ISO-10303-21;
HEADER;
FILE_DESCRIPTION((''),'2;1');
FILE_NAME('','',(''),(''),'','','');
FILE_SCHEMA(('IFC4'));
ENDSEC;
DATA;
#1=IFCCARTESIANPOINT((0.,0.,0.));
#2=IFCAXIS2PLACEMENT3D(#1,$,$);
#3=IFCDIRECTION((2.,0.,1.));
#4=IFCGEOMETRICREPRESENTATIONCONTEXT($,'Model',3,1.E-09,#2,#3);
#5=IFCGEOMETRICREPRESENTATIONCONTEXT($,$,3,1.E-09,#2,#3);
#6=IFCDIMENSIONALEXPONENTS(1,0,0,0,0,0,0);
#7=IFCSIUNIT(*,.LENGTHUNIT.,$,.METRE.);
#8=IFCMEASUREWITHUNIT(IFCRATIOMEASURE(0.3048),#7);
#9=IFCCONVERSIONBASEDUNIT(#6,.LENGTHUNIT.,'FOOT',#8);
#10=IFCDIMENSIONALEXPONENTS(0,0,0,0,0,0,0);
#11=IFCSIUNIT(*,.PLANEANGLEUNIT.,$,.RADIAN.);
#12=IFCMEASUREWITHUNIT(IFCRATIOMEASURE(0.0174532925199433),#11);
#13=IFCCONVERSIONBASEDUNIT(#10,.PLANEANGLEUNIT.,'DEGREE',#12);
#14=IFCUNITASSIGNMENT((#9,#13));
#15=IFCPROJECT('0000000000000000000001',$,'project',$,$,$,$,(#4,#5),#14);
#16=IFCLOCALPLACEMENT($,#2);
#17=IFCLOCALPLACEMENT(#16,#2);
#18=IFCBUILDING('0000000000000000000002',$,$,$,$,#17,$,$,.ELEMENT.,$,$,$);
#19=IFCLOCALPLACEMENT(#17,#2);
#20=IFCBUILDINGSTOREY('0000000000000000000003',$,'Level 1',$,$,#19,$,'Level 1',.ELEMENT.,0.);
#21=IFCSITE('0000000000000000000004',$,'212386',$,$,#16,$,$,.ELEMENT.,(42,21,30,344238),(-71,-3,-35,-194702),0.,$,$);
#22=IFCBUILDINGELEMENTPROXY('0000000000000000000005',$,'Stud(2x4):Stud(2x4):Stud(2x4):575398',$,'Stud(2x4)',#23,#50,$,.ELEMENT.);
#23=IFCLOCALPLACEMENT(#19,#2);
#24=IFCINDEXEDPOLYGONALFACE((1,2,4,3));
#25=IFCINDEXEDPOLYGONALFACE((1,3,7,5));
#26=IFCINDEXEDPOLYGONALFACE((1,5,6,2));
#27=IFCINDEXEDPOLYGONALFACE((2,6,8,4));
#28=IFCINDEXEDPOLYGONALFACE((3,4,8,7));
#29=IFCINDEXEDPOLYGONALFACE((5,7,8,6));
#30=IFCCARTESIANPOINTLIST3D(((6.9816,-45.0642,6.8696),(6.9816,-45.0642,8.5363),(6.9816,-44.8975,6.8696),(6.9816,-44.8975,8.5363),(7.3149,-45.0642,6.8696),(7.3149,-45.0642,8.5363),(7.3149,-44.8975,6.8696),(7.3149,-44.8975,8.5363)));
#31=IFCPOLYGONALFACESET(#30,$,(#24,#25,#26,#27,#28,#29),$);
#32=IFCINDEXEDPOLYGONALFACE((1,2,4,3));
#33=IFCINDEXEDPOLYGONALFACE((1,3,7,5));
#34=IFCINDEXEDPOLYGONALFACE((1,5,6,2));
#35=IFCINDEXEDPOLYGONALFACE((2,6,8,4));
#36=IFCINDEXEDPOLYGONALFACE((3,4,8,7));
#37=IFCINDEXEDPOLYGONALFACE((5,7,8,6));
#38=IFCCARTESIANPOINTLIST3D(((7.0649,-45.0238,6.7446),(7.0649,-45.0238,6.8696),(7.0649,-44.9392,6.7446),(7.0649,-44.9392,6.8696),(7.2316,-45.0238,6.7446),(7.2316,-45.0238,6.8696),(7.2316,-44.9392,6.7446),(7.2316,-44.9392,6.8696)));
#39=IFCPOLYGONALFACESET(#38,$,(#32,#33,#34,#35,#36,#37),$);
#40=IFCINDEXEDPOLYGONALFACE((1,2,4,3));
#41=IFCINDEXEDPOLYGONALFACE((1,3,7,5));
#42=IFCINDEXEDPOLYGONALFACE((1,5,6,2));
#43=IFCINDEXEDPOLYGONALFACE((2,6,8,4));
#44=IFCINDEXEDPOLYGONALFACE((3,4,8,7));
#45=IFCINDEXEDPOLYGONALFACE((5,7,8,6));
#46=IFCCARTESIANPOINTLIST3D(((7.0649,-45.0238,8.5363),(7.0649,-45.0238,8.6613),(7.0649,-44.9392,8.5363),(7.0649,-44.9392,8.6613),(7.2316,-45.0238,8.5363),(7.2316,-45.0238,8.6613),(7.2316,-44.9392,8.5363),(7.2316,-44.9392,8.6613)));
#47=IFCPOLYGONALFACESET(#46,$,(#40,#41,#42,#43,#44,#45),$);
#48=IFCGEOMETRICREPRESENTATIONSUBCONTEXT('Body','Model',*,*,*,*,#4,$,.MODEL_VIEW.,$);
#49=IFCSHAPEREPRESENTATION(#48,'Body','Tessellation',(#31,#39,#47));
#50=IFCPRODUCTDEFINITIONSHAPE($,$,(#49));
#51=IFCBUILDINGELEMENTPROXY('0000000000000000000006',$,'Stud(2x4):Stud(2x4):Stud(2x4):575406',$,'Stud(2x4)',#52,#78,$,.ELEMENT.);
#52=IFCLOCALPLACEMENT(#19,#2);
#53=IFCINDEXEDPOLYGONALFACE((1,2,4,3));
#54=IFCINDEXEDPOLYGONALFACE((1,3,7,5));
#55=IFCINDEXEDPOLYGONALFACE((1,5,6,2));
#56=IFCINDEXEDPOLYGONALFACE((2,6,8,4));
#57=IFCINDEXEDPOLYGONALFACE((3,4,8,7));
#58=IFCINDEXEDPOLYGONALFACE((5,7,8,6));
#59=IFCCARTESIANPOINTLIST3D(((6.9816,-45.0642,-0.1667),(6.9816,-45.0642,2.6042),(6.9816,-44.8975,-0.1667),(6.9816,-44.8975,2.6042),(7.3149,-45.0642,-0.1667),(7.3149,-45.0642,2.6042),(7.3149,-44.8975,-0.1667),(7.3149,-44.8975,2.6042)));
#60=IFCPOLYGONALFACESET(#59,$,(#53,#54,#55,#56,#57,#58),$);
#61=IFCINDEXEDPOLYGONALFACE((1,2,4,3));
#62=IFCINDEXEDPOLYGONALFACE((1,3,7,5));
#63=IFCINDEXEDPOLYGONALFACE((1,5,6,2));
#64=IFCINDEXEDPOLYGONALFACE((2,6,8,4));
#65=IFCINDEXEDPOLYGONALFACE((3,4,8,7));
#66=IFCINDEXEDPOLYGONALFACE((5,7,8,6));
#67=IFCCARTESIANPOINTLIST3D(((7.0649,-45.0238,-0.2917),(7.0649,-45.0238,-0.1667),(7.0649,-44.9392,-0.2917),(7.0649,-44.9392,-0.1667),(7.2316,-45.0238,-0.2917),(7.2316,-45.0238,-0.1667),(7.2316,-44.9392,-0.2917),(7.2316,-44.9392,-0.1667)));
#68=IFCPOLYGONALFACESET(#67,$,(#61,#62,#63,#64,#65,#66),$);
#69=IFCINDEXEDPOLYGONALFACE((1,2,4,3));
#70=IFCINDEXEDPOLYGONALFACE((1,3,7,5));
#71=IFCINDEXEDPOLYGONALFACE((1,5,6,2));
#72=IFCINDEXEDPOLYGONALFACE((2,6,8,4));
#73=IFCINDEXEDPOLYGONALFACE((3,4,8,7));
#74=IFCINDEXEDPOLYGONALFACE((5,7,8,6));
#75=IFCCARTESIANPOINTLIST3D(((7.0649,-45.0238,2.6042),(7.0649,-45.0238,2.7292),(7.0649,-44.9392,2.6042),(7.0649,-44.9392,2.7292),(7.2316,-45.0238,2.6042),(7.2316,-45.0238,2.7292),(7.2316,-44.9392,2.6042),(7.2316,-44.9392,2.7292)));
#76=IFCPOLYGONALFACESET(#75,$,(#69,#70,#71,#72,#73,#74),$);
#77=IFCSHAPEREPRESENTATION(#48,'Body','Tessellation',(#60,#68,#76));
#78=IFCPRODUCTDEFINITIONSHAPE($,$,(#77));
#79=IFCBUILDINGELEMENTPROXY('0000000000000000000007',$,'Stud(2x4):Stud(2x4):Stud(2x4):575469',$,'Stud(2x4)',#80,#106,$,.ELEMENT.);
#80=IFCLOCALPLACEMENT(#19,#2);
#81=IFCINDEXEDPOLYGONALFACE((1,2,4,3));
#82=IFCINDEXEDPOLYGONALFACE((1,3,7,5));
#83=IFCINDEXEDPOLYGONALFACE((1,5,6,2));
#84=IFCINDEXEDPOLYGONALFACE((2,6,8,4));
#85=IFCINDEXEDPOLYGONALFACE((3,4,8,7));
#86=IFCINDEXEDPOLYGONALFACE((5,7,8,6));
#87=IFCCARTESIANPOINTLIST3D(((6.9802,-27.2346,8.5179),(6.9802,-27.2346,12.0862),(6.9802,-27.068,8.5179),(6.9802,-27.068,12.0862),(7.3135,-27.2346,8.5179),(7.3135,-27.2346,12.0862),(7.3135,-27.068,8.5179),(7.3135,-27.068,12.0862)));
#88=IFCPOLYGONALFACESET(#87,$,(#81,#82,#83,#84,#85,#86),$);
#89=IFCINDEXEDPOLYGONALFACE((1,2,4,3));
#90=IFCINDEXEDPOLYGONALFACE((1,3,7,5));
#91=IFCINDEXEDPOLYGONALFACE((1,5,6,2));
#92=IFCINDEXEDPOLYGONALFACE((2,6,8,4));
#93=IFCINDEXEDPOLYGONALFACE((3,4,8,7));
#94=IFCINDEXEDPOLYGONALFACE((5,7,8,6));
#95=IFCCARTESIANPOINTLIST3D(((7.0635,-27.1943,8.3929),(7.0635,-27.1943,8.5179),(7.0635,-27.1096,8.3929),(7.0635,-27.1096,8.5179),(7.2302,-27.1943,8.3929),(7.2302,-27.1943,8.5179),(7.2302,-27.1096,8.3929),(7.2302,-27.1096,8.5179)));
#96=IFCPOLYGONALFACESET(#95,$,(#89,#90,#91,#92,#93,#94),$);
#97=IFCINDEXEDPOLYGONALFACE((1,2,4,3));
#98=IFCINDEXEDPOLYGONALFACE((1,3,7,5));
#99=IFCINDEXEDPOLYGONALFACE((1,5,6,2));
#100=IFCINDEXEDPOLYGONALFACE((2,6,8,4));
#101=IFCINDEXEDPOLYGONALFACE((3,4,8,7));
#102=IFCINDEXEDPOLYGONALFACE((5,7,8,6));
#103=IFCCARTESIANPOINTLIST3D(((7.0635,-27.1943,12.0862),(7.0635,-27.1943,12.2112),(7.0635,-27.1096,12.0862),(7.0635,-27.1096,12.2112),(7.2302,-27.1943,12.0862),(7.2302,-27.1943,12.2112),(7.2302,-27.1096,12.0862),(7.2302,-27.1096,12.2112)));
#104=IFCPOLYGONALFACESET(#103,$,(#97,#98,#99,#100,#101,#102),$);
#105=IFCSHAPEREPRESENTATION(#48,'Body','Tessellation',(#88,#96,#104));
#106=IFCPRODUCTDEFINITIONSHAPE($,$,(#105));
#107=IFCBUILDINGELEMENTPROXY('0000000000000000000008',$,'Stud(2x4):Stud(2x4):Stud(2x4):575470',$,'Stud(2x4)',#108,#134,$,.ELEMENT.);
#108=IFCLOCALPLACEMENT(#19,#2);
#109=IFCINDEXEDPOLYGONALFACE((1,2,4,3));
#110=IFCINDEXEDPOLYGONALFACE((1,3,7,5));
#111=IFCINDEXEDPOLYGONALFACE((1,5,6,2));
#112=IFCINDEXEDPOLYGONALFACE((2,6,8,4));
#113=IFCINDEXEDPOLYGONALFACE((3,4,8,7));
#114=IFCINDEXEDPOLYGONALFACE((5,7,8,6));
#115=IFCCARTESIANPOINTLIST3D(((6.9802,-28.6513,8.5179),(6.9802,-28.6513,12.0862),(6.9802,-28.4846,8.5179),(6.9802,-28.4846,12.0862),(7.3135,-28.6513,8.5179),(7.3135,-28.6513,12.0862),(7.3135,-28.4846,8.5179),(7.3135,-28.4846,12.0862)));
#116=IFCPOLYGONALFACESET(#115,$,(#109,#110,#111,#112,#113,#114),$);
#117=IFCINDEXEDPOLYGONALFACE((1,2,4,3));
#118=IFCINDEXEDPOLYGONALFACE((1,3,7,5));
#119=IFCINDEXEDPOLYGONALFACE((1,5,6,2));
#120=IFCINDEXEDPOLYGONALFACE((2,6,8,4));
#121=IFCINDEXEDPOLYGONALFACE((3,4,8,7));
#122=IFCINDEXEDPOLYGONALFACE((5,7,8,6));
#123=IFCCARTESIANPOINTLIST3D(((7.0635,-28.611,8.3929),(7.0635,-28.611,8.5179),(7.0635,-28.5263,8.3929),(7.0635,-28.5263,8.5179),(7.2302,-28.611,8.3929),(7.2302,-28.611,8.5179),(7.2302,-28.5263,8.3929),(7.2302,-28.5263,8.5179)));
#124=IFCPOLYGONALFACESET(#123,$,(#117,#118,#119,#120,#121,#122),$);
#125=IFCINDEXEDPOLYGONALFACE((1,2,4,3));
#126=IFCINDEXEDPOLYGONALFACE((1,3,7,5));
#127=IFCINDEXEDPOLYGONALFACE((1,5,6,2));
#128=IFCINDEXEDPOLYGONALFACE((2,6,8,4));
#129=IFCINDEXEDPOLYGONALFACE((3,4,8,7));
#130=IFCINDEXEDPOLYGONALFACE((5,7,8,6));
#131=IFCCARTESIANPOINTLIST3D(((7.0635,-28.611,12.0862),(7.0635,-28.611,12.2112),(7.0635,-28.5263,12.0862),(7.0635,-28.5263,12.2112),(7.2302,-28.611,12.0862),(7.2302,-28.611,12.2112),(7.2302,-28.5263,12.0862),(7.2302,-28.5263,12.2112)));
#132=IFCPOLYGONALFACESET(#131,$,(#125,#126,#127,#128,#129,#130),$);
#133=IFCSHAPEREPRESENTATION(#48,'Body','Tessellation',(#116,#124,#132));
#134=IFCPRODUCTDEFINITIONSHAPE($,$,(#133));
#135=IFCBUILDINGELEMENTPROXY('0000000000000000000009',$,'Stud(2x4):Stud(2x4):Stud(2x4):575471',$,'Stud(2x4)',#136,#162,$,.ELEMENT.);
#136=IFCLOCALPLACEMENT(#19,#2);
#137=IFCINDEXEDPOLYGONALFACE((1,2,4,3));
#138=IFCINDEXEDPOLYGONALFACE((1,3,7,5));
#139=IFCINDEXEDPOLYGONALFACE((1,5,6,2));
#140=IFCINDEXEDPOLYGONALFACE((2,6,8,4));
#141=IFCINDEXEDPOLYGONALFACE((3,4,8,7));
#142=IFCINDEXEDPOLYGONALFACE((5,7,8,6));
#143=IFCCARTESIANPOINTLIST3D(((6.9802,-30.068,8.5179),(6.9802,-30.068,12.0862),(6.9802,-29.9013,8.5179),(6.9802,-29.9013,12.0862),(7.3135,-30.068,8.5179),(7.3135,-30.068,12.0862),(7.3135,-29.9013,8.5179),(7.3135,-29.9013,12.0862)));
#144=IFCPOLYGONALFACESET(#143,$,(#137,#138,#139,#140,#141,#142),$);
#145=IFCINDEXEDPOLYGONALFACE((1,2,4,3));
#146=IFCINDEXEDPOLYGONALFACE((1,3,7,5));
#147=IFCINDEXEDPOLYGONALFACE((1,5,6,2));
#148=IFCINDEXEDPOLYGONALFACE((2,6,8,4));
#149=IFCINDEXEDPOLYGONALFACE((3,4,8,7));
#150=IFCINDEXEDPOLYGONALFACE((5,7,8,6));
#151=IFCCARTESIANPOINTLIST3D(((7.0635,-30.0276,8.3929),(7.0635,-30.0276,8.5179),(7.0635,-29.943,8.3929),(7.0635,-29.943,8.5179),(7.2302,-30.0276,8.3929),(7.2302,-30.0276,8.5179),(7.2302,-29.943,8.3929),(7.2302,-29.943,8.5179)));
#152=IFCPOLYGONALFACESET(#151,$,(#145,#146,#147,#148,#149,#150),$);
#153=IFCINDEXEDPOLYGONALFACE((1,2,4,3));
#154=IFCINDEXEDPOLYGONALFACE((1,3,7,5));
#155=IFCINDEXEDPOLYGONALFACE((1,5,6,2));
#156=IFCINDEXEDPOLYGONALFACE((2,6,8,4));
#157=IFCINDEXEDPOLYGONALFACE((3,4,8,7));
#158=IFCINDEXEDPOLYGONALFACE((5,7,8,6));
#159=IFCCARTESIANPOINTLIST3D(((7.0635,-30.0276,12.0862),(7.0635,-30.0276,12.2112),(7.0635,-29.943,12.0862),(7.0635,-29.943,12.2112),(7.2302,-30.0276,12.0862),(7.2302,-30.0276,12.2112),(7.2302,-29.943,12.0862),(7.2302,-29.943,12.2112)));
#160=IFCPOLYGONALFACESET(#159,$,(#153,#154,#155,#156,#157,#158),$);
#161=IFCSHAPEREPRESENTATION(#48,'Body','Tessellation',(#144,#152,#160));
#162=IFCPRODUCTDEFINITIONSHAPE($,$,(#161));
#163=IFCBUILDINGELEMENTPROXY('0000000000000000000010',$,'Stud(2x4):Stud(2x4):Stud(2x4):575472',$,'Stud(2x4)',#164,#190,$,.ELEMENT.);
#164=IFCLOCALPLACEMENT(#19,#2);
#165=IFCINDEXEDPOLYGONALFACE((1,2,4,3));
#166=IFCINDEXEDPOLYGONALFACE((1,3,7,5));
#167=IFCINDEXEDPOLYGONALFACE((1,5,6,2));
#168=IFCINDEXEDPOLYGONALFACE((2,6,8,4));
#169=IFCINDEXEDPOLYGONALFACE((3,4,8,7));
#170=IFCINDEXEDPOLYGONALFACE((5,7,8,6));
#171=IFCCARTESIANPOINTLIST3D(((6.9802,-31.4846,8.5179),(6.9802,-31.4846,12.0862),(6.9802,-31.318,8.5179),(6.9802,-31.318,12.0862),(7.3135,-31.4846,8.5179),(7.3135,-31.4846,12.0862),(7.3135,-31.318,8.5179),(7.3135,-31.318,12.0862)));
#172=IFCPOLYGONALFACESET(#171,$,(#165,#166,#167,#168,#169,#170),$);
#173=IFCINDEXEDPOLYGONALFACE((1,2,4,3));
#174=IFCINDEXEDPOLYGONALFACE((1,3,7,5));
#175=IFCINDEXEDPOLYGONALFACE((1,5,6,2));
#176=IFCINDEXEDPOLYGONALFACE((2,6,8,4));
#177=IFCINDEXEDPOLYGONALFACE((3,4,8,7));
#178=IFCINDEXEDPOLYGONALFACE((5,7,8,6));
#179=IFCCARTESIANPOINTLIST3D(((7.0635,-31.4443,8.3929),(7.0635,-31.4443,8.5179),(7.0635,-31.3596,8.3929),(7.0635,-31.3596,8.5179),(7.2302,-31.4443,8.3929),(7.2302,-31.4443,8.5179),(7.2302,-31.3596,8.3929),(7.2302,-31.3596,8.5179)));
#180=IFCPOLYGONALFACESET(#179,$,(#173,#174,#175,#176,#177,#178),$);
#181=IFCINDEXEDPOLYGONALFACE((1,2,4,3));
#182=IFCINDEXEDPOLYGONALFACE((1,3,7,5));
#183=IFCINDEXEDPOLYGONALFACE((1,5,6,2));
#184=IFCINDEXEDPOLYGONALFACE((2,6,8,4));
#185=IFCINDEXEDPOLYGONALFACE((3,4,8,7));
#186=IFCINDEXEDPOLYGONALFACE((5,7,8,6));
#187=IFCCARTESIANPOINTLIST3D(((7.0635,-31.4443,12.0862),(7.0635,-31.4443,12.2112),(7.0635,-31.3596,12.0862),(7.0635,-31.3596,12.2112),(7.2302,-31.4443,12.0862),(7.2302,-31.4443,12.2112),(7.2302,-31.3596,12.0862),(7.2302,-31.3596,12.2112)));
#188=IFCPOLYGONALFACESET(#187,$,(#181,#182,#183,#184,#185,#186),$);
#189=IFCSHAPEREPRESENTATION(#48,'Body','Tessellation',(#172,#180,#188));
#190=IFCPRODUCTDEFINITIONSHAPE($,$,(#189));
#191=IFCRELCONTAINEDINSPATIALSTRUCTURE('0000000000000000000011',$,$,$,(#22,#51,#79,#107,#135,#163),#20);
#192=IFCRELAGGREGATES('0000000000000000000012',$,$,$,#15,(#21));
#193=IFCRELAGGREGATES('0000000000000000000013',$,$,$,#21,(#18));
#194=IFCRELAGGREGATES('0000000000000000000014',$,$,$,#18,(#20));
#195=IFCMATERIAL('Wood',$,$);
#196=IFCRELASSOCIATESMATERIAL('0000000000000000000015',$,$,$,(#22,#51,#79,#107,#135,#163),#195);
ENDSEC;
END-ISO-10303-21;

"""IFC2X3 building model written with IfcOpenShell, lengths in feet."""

from ifc_helpers import new_model, entity, si_unit, converted_unit, direction, frame, frame_2d, origin, place, context, subcontext, project, spatial, rectangle, extrude, source, transform, mapped, material, element, save


model = new_model("IFC2X3")

# Units and contexts
model_context = context("Model", 3, precision=1e-09, world=origin(), true_north=direction((2.0, 0.0, 1.0)))
context_of_model = context(None, 3, precision=1e-09, world=origin(), true_north=direction((2.0, 0.0, 1.0)))
body_context = subcontext(model_context, "Body", "Model", "MODEL_VIEW")
ifc_project = project(units=[converted_unit("LENGTHUNIT", "FOOT", entity("IfcRatioMeasure", 0.3048), si_unit("LENGTHUNIT", "METRE"), dimensions=[1, 0, 0, 0, 0, 0, 0]), converted_unit("PLANEANGLEUNIT", "DEGREE", entity("IfcRatioMeasure", 0.0174532925199433), si_unit("PLANEANGLEUNIT", "RADIAN"), dimensions=[0, 0, 0, 0, 0, 0, 0])], contexts=[model_context, context_of_model])

# Site, building, storey
site_placement = place(None, origin())
site = spatial("IfcSite", under=ifc_project, at=site_placement, Name="212386", CompositionType="ELEMENT", RefLatitude=(42, 21, 30, 344238), RefLongitude=(-71, -3, -35, -194702), RefElevation=0.0)
building_placement = place(site_placement, origin())
building = spatial("IfcBuilding", under=site, at=building_placement, CompositionType="ELEMENT")
storey_placement = place(building_placement, origin())
storey = spatial("IfcBuildingStorey", under=building, at=storey_placement, Name="Level 1", LongName="Level 1", CompositionType="ELEMENT", Elevation=0.0)

# Building element proxies
ifc_material = material(Name="Wood")
shared_shape_1 = source(origin(), body_context, "Body", "SweptSolid", [
    extrude(rectangle(XDim=0.3333, YDim=0.1667, at=frame_2d((0.0, 0.0), x_axis=(1.0, 0.0))), frame((7.1482, -44.9808, 6.8696), z_axis=(0.0, 0.0, 1.0), x_axis=(-1.0, 0.0, 0.0)), (0.0, 0.0, 1.0), 1.6667),
    extrude(rectangle(XDim=0.1667, YDim=0.0847, at=frame_2d((0.0, 0.0), x_axis=(1.0, 0.0))), frame((7.1482, -44.9815, 6.7446), z_axis=(0.0, 0.0, 1.0), x_axis=(-1.0, 0.0, 0.0)), (0.0, 0.0, 1.0), 0.125),
    extrude(rectangle(XDim=0.0847, YDim=0.1667, at=frame_2d((0.0, 0.0), x_axis=(1.0, 0.0))), frame((7.1482, -44.9815, 8.5363), z_axis=(0.0, 0.0, 1.0), x_axis=(0.0, -1.0, 0.0)), (0.0, 0.0, 1.0), 0.125),
])
proxy_1_placement = place(storey_placement, origin())
element("IfcBuildingElementProxy", 1, at=proxy_1_placement, inside=storey, material=ifc_material, Name="Stud(2x4):Stud(2x4):Stud(2x4):575398", ObjectType="Stud(2x4)", CompositionType="ELEMENT", context=body_context, shape_type="MappedRepresentation", body=[
    mapped(shared_shape_1, transform((0.0, 0.0, 0.0), scale=1.0)),
])
shared_shape_2 = source(origin(), body_context, "Body", "SweptSolid", [
    extrude(rectangle(XDim=0.3333, YDim=0.1667, at=frame_2d((0.0, 0.0), x_axis=(1.0, 0.0))), frame((7.1482, -44.9808, -0.1667), z_axis=(0.0, 0.0, 1.0), x_axis=(-1.0, 0.0, 0.0)), (0.0, 0.0, 1.0), 2.7708),
    extrude(rectangle(XDim=0.1667, YDim=0.0847, at=frame_2d((0.0, 0.0), x_axis=(1.0, 0.0))), frame((7.1482, -44.9815, -0.2917), z_axis=(0.0, 0.0, 1.0), x_axis=(-1.0, 0.0, 0.0)), (0.0, 0.0, 1.0), 0.125),
    extrude(rectangle(XDim=0.0847, YDim=0.1667, at=frame_2d((0.0, 0.0), x_axis=(1.0, 0.0))), frame((7.1482, -44.9815, 2.6042), z_axis=(0.0, 0.0, 1.0), x_axis=(0.0, -1.0, 0.0)), (0.0, 0.0, 1.0), 0.125),
])
proxy_2_placement = place(storey_placement, origin())
element("IfcBuildingElementProxy", 2, at=proxy_2_placement, inside=storey, material=ifc_material, Name="Stud(2x4):Stud(2x4):Stud(2x4):575406", ObjectType="Stud(2x4)", CompositionType="ELEMENT", context=body_context, shape_type="MappedRepresentation", body=[
    mapped(shared_shape_2, transform((0.0, 0.0, 0.0), scale=1.0)),
])
shared_shape_3 = source(origin(), body_context, "Body", "SweptSolid", [
    extrude(rectangle(XDim=0.3333, YDim=0.1667, at=frame_2d((0.0, 0.0), x_axis=(1.0, 0.0))), frame((7.1469, -27.1513, 8.5179), z_axis=(0.0, 0.0, 1.0), x_axis=(-1.0, 0.0, 0.0)), (0.0, 0.0, 1.0), 3.5684),
    extrude(rectangle(XDim=0.1667, YDim=0.0847, at=frame_2d((0.0, 0.0), x_axis=(1.0, 0.0))), frame((7.1469, -27.152, 8.3929), z_axis=(0.0, 0.0, 1.0), x_axis=(-1.0, 0.0, 0.0)), (0.0, 0.0, 1.0), 0.125),
    extrude(rectangle(XDim=0.0847, YDim=0.1667, at=frame_2d((0.0, 0.0), x_axis=(1.0, 0.0))), frame((7.1469, -27.152, 12.0862), z_axis=(0.0, 0.0, 1.0), x_axis=(0.0, -1.0, 0.0)), (0.0, 0.0, 1.0), 0.125),
])
proxy_3_placement = place(storey_placement, origin())
element("IfcBuildingElementProxy", 3, at=proxy_3_placement, inside=storey, material=ifc_material, Name="Stud(2x4):Stud(2x4):Stud(2x4):575469", ObjectType="Stud(2x4)", CompositionType="ELEMENT", context=body_context, shape_type="MappedRepresentation", body=[
    mapped(shared_shape_3, transform((0.0, 0.0, 0.0), scale=1.0)),
])
shared_shape_4 = source(origin(), body_context, "Body", "SweptSolid", [
    extrude(rectangle(XDim=0.3333, YDim=0.1667, at=frame_2d((0.0, 0.0), x_axis=(1.0, 0.0))), frame((7.1469, -28.568, 8.5179), z_axis=(0.0, 0.0, 1.0), x_axis=(-1.0, 0.0, 0.0)), (0.0, 0.0, 1.0), 3.5684),
    extrude(rectangle(XDim=0.1667, YDim=0.0847, at=frame_2d((0.0, 0.0), x_axis=(1.0, 0.0))), frame((7.1469, -28.5686, 8.3929), z_axis=(0.0, 0.0, 1.0), x_axis=(-1.0, 0.0, 0.0)), (0.0, 0.0, 1.0), 0.125),
    extrude(rectangle(XDim=0.0847, YDim=0.1667, at=frame_2d((0.0, 0.0), x_axis=(1.0, 0.0))), frame((7.1469, -28.5686, 12.0862), z_axis=(0.0, 0.0, 1.0), x_axis=(0.0, -1.0, 0.0)), (0.0, 0.0, 1.0), 0.125),
])
proxy_4_placement = place(storey_placement, origin())
element("IfcBuildingElementProxy", 4, at=proxy_4_placement, inside=storey, material=ifc_material, Name="Stud(2x4):Stud(2x4):Stud(2x4):575470", ObjectType="Stud(2x4)", CompositionType="ELEMENT", context=body_context, shape_type="MappedRepresentation", body=[
    mapped(shared_shape_4, transform((0.0, 0.0, 0.0), scale=1.0)),
])
shared_shape_5 = source(origin(), body_context, "Body", "SweptSolid", [
    extrude(rectangle(XDim=0.3333, YDim=0.1667, at=frame_2d((0.0, 0.0), x_axis=(1.0, 0.0))), frame((7.1469, -29.9846, 8.5179), z_axis=(0.0, 0.0, 1.0), x_axis=(-1.0, 0.0, 0.0)), (0.0, 0.0, 1.0), 3.5684),
    extrude(rectangle(XDim=0.1667, YDim=0.0847, at=frame_2d((0.0, 0.0), x_axis=(1.0, 0.0))), frame((7.1469, -29.9853, 8.3929), z_axis=(0.0, 0.0, 1.0), x_axis=(-1.0, 0.0, 0.0)), (0.0, 0.0, 1.0), 0.125),
    extrude(rectangle(XDim=0.0847, YDim=0.1667, at=frame_2d((0.0, 0.0), x_axis=(1.0, 0.0))), frame((7.1469, -29.9853, 12.0862), z_axis=(0.0, 0.0, 1.0), x_axis=(0.0, -1.0, 0.0)), (0.0, 0.0, 1.0), 0.125),
])
proxy_5_placement = place(storey_placement, origin())
element("IfcBuildingElementProxy", 5, at=proxy_5_placement, inside=storey, material=ifc_material, Name="Stud(2x4):Stud(2x4):Stud(2x4):575471", ObjectType="Stud(2x4)", CompositionType="ELEMENT", context=body_context, shape_type="MappedRepresentation", body=[
    mapped(shared_shape_5, transform((0.0, 0.0, 0.0), scale=1.0)),
])
shared_shape_6 = source(origin(), body_context, "Body", "SweptSolid", [
    extrude(rectangle(XDim=0.3333, YDim=0.1667, at=frame_2d((0.0, 0.0), x_axis=(1.0, 0.0))), frame((7.1469, -31.4013, 8.5179), z_axis=(0.0, 0.0, 1.0), x_axis=(-1.0, 0.0, 0.0)), (0.0, 0.0, 1.0), 3.5684),
    extrude(rectangle(XDim=0.1667, YDim=0.0847, at=frame_2d((0.0, 0.0), x_axis=(1.0, 0.0))), frame((7.1469, -31.402, 8.3929), z_axis=(0.0, 0.0, 1.0), x_axis=(-1.0, 0.0, 0.0)), (0.0, 0.0, 1.0), 0.125),
    extrude(rectangle(XDim=0.0847, YDim=0.1667, at=frame_2d((0.0, 0.0), x_axis=(1.0, 0.0))), frame((7.1469, -31.402, 12.0862), z_axis=(0.0, 0.0, 1.0), x_axis=(0.0, -1.0, 0.0)), (0.0, 0.0, 1.0), 0.125),
])
proxy_6_placement = place(storey_placement, origin())
element("IfcBuildingElementProxy", 6, at=proxy_6_placement, inside=storey, material=ifc_material, Name="Stud(2x4):Stud(2x4):Stud(2x4):575472", ObjectType="Stud(2x4)", CompositionType="ELEMENT", context=body_context, shape_type="MappedRepresentation", body=[
    mapped(shared_shape_6, transform((0.0, 0.0, 0.0), scale=1.0)),
])

save(model, "model.ifc")
